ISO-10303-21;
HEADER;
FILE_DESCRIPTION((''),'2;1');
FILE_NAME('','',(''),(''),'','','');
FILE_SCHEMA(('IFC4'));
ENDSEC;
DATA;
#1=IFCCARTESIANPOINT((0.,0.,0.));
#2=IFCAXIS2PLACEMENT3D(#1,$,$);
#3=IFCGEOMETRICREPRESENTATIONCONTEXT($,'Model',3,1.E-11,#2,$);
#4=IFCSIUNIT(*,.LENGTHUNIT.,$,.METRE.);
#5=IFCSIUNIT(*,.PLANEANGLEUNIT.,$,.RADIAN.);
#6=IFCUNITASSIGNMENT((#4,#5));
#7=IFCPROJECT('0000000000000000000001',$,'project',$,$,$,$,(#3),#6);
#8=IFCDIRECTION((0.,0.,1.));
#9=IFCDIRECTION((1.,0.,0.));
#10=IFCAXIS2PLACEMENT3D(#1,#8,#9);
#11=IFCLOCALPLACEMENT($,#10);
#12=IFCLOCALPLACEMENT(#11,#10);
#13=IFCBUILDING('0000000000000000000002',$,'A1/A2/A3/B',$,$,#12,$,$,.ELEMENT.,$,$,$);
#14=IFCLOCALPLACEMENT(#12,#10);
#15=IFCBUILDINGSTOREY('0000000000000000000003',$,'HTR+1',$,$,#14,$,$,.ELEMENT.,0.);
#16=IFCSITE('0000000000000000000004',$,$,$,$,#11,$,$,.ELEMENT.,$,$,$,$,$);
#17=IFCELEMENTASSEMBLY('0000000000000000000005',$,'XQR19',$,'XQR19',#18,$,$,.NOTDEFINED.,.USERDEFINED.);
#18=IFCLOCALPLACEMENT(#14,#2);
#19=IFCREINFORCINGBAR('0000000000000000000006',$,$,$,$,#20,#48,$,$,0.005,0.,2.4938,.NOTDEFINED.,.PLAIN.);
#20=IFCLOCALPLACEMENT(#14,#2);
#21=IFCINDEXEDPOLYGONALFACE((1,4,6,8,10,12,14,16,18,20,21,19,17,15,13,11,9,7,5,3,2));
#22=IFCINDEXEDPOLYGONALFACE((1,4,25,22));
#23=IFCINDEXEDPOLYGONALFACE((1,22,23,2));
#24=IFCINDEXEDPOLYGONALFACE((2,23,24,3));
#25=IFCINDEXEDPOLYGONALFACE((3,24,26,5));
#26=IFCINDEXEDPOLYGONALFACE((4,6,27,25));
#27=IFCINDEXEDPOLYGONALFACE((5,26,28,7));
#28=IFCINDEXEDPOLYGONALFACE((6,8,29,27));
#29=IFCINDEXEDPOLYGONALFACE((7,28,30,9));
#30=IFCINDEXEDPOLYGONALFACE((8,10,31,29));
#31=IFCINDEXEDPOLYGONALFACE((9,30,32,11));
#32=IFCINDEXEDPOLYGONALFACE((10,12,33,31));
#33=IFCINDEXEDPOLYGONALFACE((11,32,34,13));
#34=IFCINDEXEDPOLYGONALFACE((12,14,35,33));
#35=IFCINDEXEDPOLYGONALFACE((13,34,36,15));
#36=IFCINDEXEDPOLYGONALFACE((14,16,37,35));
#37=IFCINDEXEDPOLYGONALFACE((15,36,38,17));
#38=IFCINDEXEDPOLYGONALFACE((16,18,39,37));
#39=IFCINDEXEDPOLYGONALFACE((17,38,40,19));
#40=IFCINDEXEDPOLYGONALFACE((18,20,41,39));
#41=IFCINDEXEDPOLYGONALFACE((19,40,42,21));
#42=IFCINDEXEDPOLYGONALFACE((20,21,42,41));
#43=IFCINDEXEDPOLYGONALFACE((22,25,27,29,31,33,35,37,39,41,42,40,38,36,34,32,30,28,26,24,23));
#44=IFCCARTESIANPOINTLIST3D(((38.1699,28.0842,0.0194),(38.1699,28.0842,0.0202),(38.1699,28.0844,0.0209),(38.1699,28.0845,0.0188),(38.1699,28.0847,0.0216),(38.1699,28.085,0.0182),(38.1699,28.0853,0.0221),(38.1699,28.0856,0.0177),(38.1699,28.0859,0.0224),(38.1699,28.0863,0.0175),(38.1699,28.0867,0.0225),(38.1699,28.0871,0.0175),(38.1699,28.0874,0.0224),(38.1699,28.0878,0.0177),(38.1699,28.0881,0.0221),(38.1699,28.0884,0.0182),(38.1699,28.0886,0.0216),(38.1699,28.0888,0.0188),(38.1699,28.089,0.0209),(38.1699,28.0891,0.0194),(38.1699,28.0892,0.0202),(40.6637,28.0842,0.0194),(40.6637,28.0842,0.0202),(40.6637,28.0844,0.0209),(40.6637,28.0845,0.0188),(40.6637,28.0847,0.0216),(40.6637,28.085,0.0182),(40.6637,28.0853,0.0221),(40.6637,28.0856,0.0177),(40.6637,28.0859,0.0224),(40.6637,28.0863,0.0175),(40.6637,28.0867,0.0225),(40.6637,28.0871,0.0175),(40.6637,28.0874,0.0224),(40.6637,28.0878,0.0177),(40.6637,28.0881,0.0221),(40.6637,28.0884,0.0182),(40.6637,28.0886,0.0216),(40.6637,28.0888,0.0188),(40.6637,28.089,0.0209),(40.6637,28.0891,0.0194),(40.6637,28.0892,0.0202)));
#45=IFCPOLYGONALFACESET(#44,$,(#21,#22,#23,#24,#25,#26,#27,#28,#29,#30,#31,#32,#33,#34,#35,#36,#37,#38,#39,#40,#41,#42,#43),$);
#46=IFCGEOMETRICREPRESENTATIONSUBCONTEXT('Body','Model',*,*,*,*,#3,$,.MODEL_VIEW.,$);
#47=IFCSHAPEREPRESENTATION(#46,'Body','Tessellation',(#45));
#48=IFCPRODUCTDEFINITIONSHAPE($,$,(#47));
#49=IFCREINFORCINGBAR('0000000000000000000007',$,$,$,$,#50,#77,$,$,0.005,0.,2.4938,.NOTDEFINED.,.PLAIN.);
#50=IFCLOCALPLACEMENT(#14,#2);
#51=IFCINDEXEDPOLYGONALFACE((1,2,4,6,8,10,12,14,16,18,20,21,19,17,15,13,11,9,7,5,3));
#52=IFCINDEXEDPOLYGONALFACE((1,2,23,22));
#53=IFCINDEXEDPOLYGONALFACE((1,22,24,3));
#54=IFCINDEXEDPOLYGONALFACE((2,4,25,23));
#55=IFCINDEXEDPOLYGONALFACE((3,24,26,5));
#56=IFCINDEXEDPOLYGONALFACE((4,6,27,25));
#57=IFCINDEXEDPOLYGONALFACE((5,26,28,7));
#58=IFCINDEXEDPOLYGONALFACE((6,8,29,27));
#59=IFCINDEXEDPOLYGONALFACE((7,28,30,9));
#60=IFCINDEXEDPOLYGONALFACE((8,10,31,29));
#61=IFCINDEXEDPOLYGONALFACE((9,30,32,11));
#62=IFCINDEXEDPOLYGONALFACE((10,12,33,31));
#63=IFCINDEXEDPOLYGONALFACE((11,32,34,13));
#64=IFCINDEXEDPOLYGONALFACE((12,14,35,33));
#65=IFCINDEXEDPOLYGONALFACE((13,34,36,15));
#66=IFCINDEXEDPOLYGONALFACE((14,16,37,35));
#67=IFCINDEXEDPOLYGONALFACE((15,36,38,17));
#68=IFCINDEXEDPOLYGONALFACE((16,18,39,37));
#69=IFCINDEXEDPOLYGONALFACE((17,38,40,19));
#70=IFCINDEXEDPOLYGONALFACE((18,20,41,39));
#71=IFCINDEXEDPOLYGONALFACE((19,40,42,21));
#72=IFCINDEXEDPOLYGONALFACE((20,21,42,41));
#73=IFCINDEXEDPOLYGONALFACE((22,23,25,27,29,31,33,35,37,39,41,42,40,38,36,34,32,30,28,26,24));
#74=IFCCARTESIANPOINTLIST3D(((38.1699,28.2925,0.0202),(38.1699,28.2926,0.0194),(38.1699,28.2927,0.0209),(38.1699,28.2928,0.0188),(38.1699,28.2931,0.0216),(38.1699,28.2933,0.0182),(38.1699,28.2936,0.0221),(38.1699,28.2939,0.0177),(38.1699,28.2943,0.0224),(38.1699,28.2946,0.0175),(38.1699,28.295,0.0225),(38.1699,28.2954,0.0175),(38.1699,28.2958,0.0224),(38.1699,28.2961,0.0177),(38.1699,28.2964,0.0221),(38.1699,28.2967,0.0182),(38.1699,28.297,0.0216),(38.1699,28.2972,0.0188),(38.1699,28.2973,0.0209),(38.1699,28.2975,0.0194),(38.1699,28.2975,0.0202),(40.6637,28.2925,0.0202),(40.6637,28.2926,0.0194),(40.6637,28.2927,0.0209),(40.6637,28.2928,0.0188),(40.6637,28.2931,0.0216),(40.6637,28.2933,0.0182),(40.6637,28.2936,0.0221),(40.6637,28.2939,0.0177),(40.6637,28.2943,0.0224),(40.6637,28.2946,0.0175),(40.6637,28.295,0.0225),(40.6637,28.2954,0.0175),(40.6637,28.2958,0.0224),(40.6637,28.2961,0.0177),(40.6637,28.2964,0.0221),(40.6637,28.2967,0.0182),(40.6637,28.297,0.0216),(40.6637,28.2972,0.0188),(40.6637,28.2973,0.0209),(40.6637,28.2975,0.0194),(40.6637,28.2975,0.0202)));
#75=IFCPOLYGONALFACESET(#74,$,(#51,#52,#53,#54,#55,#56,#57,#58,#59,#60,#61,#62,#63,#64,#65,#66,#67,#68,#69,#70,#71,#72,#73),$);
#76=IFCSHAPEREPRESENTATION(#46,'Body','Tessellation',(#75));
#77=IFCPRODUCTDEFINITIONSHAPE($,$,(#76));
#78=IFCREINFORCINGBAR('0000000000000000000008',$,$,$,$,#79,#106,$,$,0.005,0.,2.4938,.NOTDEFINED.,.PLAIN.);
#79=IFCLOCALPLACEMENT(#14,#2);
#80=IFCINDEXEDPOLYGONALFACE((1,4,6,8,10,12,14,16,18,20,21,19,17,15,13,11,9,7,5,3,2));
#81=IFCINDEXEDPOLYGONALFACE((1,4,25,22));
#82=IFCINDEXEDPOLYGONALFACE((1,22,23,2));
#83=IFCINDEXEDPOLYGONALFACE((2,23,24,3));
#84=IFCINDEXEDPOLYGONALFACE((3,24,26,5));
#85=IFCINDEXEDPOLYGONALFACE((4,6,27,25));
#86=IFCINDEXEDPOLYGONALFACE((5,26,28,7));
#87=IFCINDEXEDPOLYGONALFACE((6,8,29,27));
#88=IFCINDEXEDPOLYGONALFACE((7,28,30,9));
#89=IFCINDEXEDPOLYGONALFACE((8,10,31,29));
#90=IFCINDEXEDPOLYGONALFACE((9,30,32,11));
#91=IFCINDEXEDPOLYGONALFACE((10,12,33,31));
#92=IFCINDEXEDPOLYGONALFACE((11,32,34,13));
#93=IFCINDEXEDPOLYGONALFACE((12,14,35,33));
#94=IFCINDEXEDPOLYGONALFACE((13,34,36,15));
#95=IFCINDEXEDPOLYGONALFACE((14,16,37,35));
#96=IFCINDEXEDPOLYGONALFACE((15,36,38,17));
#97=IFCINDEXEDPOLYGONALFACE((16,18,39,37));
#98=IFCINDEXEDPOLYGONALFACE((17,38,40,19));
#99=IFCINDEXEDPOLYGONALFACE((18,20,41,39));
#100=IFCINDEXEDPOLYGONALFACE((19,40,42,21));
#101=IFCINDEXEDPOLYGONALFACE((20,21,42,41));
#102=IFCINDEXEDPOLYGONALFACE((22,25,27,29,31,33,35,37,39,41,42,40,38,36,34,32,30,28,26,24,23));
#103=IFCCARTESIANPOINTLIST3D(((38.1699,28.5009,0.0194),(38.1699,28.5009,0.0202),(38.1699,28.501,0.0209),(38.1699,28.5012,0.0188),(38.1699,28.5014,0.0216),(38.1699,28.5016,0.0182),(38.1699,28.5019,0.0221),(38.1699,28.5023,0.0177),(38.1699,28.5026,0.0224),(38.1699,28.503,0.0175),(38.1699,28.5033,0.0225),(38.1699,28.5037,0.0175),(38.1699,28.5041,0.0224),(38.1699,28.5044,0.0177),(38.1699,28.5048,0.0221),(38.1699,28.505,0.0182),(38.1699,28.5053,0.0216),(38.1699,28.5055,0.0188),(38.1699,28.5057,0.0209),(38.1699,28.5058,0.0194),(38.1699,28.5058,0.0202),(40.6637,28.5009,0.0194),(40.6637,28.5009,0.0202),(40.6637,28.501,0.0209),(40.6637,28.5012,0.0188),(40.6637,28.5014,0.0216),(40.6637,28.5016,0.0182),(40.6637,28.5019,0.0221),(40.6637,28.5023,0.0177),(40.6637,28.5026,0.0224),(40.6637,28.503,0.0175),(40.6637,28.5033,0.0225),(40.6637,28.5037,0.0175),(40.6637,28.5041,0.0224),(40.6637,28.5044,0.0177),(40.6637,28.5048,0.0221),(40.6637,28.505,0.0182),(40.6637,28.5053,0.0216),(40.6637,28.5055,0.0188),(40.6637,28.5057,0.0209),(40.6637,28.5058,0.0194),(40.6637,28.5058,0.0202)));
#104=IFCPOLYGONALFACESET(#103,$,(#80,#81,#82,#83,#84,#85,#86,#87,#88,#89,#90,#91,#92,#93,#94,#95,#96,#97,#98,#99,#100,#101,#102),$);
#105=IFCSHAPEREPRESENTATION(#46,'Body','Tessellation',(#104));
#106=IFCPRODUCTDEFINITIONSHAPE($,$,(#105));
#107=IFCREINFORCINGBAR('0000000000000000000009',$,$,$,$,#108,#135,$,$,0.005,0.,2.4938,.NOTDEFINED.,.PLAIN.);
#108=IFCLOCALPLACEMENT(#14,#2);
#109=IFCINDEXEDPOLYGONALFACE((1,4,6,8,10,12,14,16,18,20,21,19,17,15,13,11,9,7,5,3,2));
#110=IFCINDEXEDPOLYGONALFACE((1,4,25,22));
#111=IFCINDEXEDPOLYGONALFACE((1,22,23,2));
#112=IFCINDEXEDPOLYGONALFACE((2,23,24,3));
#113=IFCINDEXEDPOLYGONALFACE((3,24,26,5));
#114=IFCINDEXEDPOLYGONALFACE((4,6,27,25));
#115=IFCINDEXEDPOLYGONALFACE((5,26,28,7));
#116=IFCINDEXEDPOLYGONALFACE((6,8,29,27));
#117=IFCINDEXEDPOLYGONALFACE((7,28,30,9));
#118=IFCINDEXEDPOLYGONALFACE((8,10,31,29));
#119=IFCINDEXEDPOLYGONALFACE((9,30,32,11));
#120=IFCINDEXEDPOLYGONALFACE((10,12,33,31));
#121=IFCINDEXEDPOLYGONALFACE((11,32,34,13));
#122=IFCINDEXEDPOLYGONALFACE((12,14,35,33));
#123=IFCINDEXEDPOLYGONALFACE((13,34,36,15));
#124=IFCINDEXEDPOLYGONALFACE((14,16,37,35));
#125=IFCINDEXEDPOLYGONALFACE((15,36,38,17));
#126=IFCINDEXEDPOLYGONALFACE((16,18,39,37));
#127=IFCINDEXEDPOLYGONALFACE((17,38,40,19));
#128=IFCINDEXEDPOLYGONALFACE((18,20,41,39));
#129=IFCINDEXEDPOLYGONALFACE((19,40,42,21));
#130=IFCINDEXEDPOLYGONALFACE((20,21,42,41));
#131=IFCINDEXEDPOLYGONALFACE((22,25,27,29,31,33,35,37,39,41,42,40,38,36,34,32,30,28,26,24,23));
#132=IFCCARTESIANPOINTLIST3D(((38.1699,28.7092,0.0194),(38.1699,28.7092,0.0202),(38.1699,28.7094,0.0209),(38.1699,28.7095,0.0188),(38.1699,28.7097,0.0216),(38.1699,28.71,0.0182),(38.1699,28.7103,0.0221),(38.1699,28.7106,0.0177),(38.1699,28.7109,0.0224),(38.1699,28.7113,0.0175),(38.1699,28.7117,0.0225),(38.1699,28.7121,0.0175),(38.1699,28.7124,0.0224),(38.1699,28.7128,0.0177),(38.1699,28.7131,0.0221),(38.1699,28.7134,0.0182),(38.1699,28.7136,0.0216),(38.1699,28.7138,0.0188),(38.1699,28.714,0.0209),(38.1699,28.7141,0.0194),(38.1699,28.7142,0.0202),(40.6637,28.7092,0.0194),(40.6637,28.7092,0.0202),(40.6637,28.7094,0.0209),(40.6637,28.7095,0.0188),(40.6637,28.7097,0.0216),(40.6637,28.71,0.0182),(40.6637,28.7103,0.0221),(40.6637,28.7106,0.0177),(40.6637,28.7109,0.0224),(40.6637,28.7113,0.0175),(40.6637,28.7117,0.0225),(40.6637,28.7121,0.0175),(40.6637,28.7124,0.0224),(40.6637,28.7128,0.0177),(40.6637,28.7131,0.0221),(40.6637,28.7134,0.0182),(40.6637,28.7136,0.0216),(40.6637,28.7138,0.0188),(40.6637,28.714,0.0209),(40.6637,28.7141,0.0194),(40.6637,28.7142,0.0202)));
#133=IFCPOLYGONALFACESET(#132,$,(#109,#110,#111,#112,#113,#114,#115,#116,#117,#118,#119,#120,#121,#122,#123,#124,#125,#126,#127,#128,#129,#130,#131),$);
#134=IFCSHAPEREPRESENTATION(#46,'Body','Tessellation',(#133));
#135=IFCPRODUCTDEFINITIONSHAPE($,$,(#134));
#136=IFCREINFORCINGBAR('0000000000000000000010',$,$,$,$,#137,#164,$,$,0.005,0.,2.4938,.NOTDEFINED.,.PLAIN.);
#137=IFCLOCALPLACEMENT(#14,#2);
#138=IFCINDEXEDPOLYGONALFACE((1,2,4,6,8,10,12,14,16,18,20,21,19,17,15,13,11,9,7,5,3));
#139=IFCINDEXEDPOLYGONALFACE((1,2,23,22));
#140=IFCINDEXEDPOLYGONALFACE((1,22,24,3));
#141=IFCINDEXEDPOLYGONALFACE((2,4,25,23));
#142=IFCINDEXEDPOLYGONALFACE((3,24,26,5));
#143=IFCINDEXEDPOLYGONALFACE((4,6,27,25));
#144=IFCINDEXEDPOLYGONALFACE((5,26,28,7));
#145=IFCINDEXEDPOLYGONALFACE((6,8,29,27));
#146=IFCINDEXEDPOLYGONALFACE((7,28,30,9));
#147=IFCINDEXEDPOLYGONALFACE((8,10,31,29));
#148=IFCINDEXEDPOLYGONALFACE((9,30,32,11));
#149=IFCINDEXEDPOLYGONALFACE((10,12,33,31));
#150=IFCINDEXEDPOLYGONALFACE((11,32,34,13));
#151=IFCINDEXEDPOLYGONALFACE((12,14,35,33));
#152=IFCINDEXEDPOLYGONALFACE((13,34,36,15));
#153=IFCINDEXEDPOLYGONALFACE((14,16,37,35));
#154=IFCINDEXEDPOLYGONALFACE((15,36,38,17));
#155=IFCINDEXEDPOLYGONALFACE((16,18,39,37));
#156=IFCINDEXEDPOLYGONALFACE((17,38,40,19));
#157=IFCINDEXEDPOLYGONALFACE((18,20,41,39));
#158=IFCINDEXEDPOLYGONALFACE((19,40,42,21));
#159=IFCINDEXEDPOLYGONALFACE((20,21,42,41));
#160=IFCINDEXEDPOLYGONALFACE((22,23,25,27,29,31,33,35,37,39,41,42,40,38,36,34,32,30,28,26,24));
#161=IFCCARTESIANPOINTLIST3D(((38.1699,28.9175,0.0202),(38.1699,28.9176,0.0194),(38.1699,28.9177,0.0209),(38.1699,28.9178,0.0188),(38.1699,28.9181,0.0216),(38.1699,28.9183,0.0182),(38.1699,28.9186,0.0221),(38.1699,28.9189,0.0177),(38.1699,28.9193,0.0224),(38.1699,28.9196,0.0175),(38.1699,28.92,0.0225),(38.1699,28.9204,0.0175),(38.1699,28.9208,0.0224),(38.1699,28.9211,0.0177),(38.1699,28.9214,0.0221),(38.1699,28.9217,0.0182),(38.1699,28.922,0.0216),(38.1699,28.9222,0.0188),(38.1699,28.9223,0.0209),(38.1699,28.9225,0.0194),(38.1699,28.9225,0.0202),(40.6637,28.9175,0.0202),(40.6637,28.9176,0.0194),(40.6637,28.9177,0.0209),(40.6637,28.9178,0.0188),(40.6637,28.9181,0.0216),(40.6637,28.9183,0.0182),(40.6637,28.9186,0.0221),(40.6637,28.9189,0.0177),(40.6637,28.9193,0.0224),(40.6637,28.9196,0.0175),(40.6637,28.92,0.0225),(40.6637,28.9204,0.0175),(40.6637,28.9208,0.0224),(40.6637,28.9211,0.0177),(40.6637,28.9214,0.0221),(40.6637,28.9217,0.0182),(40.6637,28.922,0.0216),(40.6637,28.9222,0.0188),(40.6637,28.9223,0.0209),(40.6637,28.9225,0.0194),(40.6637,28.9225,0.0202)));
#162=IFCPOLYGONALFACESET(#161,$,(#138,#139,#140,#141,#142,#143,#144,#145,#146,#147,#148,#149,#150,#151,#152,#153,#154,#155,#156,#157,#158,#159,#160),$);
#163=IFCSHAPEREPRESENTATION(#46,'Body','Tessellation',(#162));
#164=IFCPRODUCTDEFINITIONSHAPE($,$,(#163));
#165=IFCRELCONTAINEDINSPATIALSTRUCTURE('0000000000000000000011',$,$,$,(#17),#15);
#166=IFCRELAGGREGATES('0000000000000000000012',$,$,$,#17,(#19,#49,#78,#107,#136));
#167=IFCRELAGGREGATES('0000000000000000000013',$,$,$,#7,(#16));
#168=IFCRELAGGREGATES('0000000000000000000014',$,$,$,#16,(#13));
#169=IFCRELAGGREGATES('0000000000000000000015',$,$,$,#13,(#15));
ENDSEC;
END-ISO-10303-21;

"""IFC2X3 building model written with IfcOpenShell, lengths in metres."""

from ifc_helpers import new_model, entity, si_unit, origin, origin_with_axes, place, context, subcontext, project, spatial, shape, element, aggregate, save


model = new_model("IFC2X3")

# Units and contexts
model_context = context("Model", 3, precision=1e-11, world=origin())
body_context = subcontext(model_context, "Body", "Model", "MODEL_VIEW")
ifc_project = project(units=[si_unit("LENGTHUNIT", "METRE"), si_unit("PLANEANGLEUNIT", "RADIAN")], contexts=[model_context])

# Site, building, storey
site_placement = place(None, origin_with_axes())
site = spatial("IfcSite", under=ifc_project, at=site_placement, CompositionType="ELEMENT")
building_placement = place(site_placement, origin_with_axes())
building = spatial("IfcBuilding", under=site, at=building_placement, Name="A1/A2/A3/B", CompositionType="ELEMENT")
storey_placement = place(building_placement, origin_with_axes())
storey = spatial("IfcBuildingStorey", under=building, at=storey_placement, Name="HTR+1", CompositionType="ELEMENT", Elevation=0.0)

# Element assembly, reinforcing bars
assembly_1_placement = place(storey_placement, origin_with_axes())
assembly_1 = element("IfcElementAssembly", 1, at=assembly_1_placement, inside=storey, Name="XQR19", ObjectType="XQR19", AssemblyPlace="NOTDEFINED", PredefinedType="USERDEFINED")
reinforcing_bar_1_placement = place(assembly_1_placement, origin_with_axes())
reinforcing_bar_1 = element("IfcReinforcingBar", 2, at=reinforcing_bar_1_placement, BarLength=2.4938, BarRole="NOTDEFINED", BarSurface="PLAIN", CrossSectionArea=0.0, NominalDiameter=0.005, shapes=[
    shape(body_context, "Body", "AdvancedSweptSolid", [entity("IfcSweptDiskSolid", entity("IfcPolyline", [entity("IfcCartesianPoint", [38.1699, 28.0867, 0.02]), entity("IfcCartesianPoint", [40.6637, 28.0867, 0.02])]), 0.0025, None, 0.0, 2.4938)]),
    shape(body_context, "Body", "AdvancedSweptSolid", [entity("IfcSweptDiskSolid", entity("IfcPolyline", [entity("IfcCartesianPoint", [38.1699, 28.0867, 0.02]), entity("IfcCartesianPoint", [40.6637, 28.0867, 0.02])]), 0.0025, None, 0.0, 2.4938)]),
])
reinforcing_bar_2_placement = place(assembly_1_placement, origin_with_axes())
reinforcing_bar_2 = element("IfcReinforcingBar", 3, at=reinforcing_bar_2_placement, BarLength=2.4938, BarRole="NOTDEFINED", BarSurface="PLAIN", CrossSectionArea=0.0, NominalDiameter=0.005, shapes=[
    shape(body_context, "Body", "AdvancedSweptSolid", [entity("IfcSweptDiskSolid", entity("IfcPolyline", [entity("IfcCartesianPoint", [38.1699, 28.295, 0.02]), entity("IfcCartesianPoint", [40.6637, 28.295, 0.02])]), 0.0025, None, 0.0, 2.4938)]),
    shape(body_context, "Body", "AdvancedSweptSolid", [entity("IfcSweptDiskSolid", entity("IfcPolyline", [entity("IfcCartesianPoint", [38.1699, 28.295, 0.02]), entity("IfcCartesianPoint", [40.6637, 28.295, 0.02])]), 0.0025, None, 0.0, 2.4938)]),
])
reinforcing_bar_3_placement = place(assembly_1_placement, origin_with_axes())
reinforcing_bar_3 = element("IfcReinforcingBar", 4, at=reinforcing_bar_3_placement, BarLength=2.4938, BarRole="NOTDEFINED", BarSurface="PLAIN", CrossSectionArea=0.0, NominalDiameter=0.005, shapes=[
    shape(body_context, "Body", "AdvancedSweptSolid", [entity("IfcSweptDiskSolid", entity("IfcPolyline", [entity("IfcCartesianPoint", [38.1699, 28.5033, 0.02]), entity("IfcCartesianPoint", [40.6637, 28.5033, 0.02])]), 0.0025, None, 0.0, 2.4938)]),
    shape(body_context, "Body", "AdvancedSweptSolid", [entity("IfcSweptDiskSolid", entity("IfcPolyline", [entity("IfcCartesianPoint", [38.1699, 28.5033, 0.02]), entity("IfcCartesianPoint", [40.6637, 28.5033, 0.02])]), 0.0025, None, 0.0, 2.4938)]),
])
reinforcing_bar_4_placement = place(assembly_1_placement, origin_with_axes())
reinforcing_bar_4 = element("IfcReinforcingBar", 5, at=reinforcing_bar_4_placement, BarLength=2.4938, BarRole="NOTDEFINED", BarSurface="PLAIN", CrossSectionArea=0.0, NominalDiameter=0.005, shapes=[
    shape(body_context, "Body", "AdvancedSweptSolid", [entity("IfcSweptDiskSolid", entity("IfcPolyline", [entity("IfcCartesianPoint", [38.1699, 28.7117, 0.02]), entity("IfcCartesianPoint", [40.6637, 28.7117, 0.02])]), 0.0025, None, 0.0, 2.4938)]),
    shape(body_context, "Body", "AdvancedSweptSolid", [entity("IfcSweptDiskSolid", entity("IfcPolyline", [entity("IfcCartesianPoint", [38.1699, 28.7117, 0.02]), entity("IfcCartesianPoint", [40.6637, 28.7117, 0.02])]), 0.0025, None, 0.0, 2.4938)]),
])
reinforcing_bar_5_placement = place(assembly_1_placement, origin_with_axes())
reinforcing_bar_5 = element("IfcReinforcingBar", 6, at=reinforcing_bar_5_placement, BarLength=2.4938, BarRole="NOTDEFINED", BarSurface="PLAIN", CrossSectionArea=0.0, NominalDiameter=0.005, shapes=[
    shape(body_context, "Body", "AdvancedSweptSolid", [entity("IfcSweptDiskSolid", entity("IfcPolyline", [entity("IfcCartesianPoint", [38.1699, 28.92, 0.02]), entity("IfcCartesianPoint", [40.6637, 28.92, 0.02])]), 0.0025, None, 0.0, 2.4938)]),
    shape(body_context, "Body", "AdvancedSweptSolid", [entity("IfcSweptDiskSolid", entity("IfcPolyline", [entity("IfcCartesianPoint", [38.1699, 28.92, 0.02]), entity("IfcCartesianPoint", [40.6637, 28.92, 0.02])]), 0.0025, None, 0.0, 2.4938)]),
])
aggregate(assembly_1, [reinforcing_bar_1, reinforcing_bar_2, reinforcing_bar_3, reinforcing_bar_4, reinforcing_bar_5])

save(model, "model.ifc")
